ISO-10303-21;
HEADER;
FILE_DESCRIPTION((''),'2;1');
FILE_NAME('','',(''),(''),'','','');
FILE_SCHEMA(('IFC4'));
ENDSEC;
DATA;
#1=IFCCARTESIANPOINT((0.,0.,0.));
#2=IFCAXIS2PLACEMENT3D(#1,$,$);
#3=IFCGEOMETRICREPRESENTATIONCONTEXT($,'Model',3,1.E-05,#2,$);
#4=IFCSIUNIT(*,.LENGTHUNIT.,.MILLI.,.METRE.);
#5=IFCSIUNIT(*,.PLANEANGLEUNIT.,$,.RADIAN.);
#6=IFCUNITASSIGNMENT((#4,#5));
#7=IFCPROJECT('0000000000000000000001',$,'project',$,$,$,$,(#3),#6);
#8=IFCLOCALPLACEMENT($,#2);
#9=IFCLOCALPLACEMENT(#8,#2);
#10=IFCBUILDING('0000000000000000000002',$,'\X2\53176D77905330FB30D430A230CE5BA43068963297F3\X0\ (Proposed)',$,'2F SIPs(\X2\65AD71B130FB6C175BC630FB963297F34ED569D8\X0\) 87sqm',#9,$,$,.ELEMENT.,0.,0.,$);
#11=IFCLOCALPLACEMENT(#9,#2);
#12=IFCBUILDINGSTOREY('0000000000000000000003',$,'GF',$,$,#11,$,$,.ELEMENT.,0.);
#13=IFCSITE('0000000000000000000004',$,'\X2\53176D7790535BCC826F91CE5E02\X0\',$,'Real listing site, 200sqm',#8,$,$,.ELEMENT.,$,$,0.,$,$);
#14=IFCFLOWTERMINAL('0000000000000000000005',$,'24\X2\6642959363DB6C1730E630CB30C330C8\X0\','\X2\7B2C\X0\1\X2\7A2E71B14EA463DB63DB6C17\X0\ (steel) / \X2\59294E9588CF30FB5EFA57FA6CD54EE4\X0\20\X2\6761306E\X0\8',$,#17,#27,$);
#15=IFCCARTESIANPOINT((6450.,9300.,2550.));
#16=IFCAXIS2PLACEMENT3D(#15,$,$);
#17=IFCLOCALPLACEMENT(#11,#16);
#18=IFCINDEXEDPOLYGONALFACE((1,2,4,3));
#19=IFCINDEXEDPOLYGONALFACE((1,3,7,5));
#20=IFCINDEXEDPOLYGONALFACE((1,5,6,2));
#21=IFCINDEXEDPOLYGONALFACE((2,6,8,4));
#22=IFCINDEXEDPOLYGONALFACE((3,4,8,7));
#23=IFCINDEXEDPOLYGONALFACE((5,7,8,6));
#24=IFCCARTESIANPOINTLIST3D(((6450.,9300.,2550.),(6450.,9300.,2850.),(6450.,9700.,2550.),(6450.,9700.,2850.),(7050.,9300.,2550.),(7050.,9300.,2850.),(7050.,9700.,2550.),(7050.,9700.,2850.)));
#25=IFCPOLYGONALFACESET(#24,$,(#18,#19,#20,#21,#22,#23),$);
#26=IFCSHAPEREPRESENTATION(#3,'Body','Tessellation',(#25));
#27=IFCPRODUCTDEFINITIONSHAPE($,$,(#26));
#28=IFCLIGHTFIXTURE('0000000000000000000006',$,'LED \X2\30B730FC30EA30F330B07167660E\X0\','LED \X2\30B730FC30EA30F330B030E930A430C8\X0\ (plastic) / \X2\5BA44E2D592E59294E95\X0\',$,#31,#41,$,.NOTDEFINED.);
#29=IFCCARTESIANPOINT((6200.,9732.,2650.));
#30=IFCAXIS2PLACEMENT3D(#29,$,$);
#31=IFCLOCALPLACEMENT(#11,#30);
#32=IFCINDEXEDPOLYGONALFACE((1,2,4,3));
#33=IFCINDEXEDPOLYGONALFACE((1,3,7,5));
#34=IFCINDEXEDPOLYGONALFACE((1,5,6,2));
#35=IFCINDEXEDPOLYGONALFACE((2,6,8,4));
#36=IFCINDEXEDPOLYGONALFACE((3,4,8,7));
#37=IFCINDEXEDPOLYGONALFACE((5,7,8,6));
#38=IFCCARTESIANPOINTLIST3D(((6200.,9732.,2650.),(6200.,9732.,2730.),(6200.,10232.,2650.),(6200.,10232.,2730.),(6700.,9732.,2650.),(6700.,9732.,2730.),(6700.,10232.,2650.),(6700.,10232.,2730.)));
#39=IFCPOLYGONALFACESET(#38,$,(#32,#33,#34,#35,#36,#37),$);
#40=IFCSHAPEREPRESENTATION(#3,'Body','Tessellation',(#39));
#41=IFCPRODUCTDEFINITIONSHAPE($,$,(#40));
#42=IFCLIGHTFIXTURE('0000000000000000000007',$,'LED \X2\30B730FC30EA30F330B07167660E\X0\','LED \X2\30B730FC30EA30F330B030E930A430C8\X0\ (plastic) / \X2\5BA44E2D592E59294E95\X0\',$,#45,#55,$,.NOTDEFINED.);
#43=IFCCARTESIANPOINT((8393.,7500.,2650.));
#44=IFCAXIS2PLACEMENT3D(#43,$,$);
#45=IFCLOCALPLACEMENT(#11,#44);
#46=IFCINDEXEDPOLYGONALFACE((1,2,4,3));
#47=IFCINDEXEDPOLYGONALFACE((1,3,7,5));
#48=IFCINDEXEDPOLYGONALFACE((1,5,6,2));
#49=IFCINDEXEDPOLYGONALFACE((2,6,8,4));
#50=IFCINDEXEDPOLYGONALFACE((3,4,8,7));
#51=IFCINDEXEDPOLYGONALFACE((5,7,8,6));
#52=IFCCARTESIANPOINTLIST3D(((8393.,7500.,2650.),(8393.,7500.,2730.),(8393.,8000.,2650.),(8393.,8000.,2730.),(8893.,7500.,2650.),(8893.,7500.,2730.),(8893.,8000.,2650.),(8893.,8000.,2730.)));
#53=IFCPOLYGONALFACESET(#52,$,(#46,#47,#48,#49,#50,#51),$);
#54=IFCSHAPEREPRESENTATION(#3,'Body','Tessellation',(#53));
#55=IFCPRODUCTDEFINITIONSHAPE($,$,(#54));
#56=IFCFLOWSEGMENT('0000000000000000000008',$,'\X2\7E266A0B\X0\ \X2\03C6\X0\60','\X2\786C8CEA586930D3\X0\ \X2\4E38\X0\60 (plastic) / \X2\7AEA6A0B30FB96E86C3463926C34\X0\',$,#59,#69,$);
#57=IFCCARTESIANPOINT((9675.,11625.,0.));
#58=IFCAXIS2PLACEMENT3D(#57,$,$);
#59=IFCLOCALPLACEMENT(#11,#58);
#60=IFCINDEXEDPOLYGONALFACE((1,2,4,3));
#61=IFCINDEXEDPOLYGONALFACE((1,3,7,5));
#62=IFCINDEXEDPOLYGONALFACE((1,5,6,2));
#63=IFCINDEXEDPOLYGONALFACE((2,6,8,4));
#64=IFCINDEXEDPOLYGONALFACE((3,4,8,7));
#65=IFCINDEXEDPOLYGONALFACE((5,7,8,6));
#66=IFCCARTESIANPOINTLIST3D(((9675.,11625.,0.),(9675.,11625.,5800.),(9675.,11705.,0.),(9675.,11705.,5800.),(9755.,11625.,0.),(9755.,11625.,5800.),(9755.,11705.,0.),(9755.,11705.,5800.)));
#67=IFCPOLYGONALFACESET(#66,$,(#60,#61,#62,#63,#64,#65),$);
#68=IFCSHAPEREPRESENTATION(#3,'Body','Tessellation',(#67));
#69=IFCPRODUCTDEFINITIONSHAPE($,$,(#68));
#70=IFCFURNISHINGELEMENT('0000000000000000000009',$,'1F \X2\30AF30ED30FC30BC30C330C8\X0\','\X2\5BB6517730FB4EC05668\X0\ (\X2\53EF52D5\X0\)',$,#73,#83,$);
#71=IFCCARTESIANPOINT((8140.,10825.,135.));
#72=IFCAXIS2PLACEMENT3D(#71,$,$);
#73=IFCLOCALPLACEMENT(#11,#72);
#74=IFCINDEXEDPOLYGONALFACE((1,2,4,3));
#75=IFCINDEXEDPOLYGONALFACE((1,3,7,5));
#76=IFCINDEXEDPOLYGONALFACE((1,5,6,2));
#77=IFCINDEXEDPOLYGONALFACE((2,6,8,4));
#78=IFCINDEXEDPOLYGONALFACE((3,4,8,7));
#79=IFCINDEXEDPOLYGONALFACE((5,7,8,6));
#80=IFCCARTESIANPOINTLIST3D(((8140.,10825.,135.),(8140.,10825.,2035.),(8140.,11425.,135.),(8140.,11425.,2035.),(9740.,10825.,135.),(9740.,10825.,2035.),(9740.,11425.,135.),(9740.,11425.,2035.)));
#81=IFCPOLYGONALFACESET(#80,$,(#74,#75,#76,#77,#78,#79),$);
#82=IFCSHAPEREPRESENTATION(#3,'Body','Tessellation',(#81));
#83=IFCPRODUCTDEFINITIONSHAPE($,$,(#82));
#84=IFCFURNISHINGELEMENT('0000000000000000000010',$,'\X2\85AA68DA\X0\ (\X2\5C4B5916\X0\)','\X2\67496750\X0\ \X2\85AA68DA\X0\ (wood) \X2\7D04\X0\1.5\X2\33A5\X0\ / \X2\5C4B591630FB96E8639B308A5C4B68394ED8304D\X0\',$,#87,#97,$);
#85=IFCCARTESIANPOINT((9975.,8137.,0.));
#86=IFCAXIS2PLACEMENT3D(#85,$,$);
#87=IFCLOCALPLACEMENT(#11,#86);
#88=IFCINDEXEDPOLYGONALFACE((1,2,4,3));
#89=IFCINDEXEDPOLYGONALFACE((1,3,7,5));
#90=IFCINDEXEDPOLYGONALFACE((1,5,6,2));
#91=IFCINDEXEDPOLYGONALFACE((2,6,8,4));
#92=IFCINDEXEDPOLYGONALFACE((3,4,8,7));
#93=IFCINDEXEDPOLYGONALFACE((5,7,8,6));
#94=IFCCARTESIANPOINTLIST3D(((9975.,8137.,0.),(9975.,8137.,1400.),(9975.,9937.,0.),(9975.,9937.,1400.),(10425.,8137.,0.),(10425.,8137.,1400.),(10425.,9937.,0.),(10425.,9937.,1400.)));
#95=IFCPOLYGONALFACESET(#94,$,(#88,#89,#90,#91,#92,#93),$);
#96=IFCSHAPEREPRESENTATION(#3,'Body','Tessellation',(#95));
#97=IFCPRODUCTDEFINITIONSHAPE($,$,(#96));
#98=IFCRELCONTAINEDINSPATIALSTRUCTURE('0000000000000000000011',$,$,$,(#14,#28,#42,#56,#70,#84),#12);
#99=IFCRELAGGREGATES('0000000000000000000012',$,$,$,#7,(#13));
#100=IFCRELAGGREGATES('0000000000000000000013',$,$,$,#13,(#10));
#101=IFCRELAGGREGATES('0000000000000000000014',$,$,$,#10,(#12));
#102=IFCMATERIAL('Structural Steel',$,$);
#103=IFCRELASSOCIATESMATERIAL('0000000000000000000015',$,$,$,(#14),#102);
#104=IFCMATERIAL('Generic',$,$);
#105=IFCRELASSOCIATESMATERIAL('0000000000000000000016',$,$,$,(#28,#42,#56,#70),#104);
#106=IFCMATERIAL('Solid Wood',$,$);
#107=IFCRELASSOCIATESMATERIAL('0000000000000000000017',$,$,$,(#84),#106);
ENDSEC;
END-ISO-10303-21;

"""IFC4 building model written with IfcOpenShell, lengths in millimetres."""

from ifc_helpers import new_model, si_unit, frame, frame_2d, origin, place, context, project, spatial, rectangle, extrude, material, element, save


model = new_model("IFC4")

# Units and contexts
model_context = context("Model", 3, precision=1e-05, world=origin())
ifc_project = project(units=[si_unit("LENGTHUNIT", "METRE", prefix="MILLI"), si_unit("PLANEANGLEUNIT", "RADIAN")], contexts=[model_context])

# Site, building, storey
site_placement = place(None, origin())
site = spatial("IfcSite", under=ifc_project, at=site_placement, Name="北海道富良野市", ObjectType="Real listing site, 200sqm", CompositionType="ELEMENT", RefElevation=0.0)
building_placement = place(site_placement, origin())
building = spatial("IfcBuilding", under=site, at=building_placement, Name="北海道・ピアノ室と防音 (Proposed)", ObjectType="2F SIPs(断熱・気密・防音仕様) 87sqm", CompositionType="ELEMENT", ElevationOfRefHeight=0.0, ElevationOfTerrain=0.0)
storey_placement = place(building_placement, origin())
storey = spatial("IfcBuildingStorey", under=building, at=storey_placement, Name="GF", CompositionType="ELEMENT", Elevation=0.0)

# Shared definitions
ifc_material_1 = material(Name="Solid Wood")

# Shared definitions
ifc_material_2 = material(Name="Generic")

# Flow terminal
ifc_material_3 = material(Name="Structural Steel")
flow_terminal_placement = place(storey_placement, frame((6450.0, 9300.0, 2550.0)))
element("IfcFlowTerminal", 1, at=flow_terminal_placement, inside=storey, material=ifc_material_3, Name="24時間換気ユニット", Description="第1種熱交換換気 (steel) / 天井裏・建基法令20条の8", context=model_context, shape_type="SweptSolid", body=[
    extrude(rectangle(XDim=600.0, YDim=400.0, at=frame_2d((300.0, 200.0))), frame((6450.0, 9300.0, 2550.0)), (0.0, 0.0, 1.0), 300.0),
])

# Light fixtures
light_fixture_1_placement = place(storey_placement, frame((6200.0, 9732.0, 2650.0)))
element("IfcLightFixture", 2, at=light_fixture_1_placement, inside=storey, material=ifc_material_2, Name="LED シーリング照明", Description="LED シーリングライト (plastic) / 室中央天井", PredefinedType="NOTDEFINED", context=model_context, shape_type="SweptSolid", body=[
    extrude(rectangle(XDim=500.0, YDim=500.0, at=frame_2d((250.0, 250.0))), frame((6200.0, 9732.0, 2650.0)), (0.0, 0.0, 1.0), 80.0),
])
light_fixture_2_placement = place(storey_placement, frame((8393.0, 7500.0, 2650.0)))
element("IfcLightFixture", 3, at=light_fixture_2_placement, inside=storey, material=ifc_material_2, Name="LED シーリング照明", Description="LED シーリングライト (plastic) / 室中央天井", PredefinedType="NOTDEFINED", context=model_context, shape_type="SweptSolid", body=[
    extrude(rectangle(XDim=500.0, YDim=500.0, at=frame_2d((250.0, 250.0))), frame((8393.0, 7500.0, 2650.0)), (0.0, 0.0, 1.0), 80.0),
])

# Flow segment
flow_segment_placement = place(storey_placement, frame((9675.0, 11625.0, 0.0)))
element("IfcFlowSegment", 4, at=flow_segment_placement, inside=storey, material=ifc_material_2, Name="縦樋 φ60", Description="硬質塩ビ 丸60 (plastic) / 竪樋・雨水排水", context=model_context, shape_type="SweptSolid", body=[
    extrude(rectangle(XDim=80.0, YDim=80.0, at=frame_2d((40.0, 40.0))), frame((9675.0, 11625.0, 0.0)), (0.0, 0.0, 1.0), 5800.0),
])

# Furnishing elements
furnishing_1_placement = place(storey_placement, frame((8140.0, 10825.0, 135.0)))
element("IfcFurnishingElement", 5, at=furnishing_1_placement, inside=storey, material=ifc_material_2, Name="1F クローゼット", Description="家具・什器 (可動)", context=model_context, shape_type="SweptSolid", body=[
    extrude(rectangle(XDim=1600.0, YDim=600.0, at=frame_2d((800.0, 300.0))), frame((8140.0, 10825.0, 135.0)), (0.0, 0.0, 1.0), 1900.0),
])
furnishing_2_placement = place(storey_placement, frame((9975.0, 8137.0, 0.0)))
element("IfcFurnishingElement", 6, at=furnishing_2_placement, inside=storey, material=ifc_material_1, Name="薪棚 (屋外)", Description="杉材 薪棚 (wood) 約1.5㎥ / 屋外・雨掛り屋根付き", context=model_context, shape_type="SweptSolid", body=[
    extrude(rectangle(XDim=450.0, YDim=1800.0, at=frame_2d((225.0, 900.0))), frame((9975.0, 8137.0, 0.0)), (0.0, 0.0, 1.0), 1400.0),
])

save(model, "model.ifc")
